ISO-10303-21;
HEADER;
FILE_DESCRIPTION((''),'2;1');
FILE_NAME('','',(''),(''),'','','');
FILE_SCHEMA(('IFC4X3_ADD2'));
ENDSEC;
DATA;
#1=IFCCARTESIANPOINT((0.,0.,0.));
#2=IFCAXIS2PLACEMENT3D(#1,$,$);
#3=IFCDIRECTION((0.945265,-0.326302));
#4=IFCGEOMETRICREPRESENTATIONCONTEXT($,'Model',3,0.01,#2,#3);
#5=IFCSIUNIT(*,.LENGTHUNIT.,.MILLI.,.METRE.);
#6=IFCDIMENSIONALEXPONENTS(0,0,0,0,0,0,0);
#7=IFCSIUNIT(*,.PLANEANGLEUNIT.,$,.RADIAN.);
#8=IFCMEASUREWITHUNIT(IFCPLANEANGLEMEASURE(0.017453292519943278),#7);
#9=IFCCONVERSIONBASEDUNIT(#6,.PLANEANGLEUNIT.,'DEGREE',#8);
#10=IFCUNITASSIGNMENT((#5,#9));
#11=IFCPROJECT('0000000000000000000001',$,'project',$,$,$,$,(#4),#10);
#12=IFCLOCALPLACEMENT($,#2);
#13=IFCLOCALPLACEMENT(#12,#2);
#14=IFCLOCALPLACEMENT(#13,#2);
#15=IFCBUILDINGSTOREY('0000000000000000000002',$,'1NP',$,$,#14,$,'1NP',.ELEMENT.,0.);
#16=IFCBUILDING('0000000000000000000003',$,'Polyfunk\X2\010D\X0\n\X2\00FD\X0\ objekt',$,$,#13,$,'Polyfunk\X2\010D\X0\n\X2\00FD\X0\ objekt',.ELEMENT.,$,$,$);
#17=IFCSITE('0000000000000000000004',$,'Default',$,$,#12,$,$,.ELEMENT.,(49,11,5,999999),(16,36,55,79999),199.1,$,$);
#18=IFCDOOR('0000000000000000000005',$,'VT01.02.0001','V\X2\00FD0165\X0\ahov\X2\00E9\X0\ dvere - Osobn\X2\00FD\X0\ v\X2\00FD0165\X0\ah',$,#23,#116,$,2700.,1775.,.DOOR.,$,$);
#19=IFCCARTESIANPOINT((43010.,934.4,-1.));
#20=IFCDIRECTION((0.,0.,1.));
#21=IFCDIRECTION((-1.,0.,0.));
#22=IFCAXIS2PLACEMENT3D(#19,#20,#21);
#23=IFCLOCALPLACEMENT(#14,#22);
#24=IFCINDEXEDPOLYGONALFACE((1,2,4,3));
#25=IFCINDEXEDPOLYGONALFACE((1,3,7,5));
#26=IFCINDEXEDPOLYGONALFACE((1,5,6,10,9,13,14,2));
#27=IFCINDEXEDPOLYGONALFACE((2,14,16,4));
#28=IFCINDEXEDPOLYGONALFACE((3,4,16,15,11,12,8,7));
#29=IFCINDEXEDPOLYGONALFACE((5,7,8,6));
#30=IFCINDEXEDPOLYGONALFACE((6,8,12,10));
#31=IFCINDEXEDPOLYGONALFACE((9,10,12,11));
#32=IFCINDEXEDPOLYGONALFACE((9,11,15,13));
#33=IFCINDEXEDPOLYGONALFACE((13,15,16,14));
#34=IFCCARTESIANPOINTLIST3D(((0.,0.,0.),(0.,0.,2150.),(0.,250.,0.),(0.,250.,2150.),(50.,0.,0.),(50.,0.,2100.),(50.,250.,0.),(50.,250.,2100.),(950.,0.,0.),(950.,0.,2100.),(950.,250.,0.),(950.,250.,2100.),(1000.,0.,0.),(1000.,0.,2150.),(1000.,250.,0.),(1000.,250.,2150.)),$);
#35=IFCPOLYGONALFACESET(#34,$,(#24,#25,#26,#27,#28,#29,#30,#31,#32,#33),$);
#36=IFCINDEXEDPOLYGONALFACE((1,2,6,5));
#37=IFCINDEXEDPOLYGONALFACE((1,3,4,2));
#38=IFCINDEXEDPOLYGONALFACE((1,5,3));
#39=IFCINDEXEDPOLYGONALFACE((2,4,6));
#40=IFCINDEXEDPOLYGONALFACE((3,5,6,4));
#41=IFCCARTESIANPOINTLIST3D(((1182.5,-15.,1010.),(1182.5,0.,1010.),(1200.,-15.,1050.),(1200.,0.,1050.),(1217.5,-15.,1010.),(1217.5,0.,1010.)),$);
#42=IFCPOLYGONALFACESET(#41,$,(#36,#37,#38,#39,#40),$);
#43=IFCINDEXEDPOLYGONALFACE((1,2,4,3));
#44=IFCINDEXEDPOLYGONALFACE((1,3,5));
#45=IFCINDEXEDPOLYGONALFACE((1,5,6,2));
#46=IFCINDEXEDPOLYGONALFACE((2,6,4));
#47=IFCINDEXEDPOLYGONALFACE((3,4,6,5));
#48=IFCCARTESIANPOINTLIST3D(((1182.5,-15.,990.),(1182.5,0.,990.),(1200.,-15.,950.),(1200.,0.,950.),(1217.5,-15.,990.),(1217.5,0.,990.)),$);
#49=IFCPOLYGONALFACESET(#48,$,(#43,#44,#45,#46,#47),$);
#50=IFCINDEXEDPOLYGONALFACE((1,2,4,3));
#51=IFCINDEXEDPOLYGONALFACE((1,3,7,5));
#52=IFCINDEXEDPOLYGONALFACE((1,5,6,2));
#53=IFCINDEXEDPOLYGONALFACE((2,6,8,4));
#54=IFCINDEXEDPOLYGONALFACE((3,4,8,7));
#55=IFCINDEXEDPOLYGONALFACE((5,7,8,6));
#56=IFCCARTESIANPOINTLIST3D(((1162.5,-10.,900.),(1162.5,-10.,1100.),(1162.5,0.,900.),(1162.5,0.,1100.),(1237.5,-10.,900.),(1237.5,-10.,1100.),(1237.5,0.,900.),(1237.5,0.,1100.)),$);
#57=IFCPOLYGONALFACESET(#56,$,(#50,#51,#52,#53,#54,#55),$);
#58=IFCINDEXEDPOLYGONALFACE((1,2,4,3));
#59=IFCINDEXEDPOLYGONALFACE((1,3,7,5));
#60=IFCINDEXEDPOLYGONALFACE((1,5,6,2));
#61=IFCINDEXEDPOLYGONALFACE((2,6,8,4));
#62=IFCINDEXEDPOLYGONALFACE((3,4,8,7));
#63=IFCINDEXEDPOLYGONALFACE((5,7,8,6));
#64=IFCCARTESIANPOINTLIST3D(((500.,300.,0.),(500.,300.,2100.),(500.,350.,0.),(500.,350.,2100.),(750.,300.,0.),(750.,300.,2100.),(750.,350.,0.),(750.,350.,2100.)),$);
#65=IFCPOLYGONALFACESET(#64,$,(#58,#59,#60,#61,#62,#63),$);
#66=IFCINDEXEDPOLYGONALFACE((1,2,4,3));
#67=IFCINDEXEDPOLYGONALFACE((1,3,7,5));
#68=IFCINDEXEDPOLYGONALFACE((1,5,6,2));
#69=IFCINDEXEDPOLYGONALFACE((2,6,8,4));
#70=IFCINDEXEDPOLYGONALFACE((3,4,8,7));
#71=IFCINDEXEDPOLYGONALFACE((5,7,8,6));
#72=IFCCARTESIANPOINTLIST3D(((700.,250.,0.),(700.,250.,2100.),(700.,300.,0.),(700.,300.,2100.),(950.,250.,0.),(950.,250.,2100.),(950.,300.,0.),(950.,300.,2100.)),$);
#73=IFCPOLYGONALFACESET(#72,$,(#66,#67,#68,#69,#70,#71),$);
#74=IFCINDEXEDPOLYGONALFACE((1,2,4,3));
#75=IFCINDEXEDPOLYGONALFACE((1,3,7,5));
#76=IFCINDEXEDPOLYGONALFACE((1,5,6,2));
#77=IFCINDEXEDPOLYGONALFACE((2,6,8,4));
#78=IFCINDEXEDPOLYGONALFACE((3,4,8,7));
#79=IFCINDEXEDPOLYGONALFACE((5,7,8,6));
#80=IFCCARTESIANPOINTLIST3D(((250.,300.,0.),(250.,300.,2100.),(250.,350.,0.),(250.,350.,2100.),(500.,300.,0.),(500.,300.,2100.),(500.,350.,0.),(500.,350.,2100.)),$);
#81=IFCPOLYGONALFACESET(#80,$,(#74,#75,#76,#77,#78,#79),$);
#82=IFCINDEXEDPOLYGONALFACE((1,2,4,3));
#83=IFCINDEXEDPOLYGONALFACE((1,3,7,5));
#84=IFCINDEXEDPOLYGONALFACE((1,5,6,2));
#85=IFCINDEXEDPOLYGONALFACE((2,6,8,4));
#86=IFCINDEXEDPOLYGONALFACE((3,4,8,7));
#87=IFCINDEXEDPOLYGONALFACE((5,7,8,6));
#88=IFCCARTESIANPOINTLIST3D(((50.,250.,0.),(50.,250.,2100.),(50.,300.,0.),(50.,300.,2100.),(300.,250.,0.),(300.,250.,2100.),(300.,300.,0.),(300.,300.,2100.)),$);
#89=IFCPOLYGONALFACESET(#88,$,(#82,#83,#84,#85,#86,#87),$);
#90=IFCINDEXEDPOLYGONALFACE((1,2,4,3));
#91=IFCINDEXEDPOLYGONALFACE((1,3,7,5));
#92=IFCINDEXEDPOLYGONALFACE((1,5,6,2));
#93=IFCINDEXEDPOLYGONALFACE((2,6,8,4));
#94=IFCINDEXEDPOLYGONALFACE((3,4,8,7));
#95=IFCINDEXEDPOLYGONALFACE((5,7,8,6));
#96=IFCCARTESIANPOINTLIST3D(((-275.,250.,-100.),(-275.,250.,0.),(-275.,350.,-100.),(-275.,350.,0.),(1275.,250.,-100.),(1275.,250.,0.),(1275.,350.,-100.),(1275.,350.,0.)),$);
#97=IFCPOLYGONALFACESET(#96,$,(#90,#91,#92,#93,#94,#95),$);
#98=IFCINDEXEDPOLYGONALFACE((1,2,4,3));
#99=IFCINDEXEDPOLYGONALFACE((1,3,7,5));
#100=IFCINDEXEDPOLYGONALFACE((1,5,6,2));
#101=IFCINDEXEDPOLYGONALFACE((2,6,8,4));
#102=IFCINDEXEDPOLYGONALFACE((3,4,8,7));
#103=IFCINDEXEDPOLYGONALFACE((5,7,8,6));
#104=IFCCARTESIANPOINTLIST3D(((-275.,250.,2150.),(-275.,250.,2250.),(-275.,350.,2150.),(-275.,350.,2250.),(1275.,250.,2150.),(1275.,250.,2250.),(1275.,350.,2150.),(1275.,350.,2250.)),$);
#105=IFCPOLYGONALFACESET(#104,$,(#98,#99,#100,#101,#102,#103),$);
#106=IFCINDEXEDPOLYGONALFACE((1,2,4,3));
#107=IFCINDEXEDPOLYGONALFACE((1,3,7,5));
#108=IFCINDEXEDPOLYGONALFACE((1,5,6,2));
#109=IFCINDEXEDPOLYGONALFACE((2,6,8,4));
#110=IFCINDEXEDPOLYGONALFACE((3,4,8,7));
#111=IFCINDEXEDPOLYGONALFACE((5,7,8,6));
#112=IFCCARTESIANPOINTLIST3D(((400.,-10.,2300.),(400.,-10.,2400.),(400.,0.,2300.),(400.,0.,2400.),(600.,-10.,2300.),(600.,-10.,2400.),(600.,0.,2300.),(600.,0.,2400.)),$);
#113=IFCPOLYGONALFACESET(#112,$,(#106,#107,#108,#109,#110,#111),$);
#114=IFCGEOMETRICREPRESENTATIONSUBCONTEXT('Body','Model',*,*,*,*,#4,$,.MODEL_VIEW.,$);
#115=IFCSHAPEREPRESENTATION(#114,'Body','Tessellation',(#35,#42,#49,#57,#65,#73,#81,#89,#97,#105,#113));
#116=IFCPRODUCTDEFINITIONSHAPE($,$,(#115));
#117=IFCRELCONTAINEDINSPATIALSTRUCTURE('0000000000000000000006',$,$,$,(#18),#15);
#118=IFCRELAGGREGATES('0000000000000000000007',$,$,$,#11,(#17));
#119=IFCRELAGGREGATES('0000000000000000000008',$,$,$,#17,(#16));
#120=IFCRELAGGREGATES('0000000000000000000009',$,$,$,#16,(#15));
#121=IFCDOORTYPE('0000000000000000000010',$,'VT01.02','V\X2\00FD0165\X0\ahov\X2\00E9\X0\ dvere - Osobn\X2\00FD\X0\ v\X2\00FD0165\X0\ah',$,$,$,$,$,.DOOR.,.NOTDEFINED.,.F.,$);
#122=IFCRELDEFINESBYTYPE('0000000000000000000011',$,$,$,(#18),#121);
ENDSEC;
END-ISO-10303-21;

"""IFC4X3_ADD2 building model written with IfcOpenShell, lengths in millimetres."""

from ifc_helpers import new_model, entity, si_unit, converted_unit, direction, frame, frame_2d, origin, origin_2d_with_axis, place, context, subcontext, project, spatial, polyline, rectangle, outline, extrude, source, transform, mapped, type_object, type_shapes, element, save


model = new_model("IFC4X3_ADD2")

# Units and contexts
model_context = context("Model", 3, precision=0.01, world=origin(), true_north=direction((0.945265, -0.326302)))
body_context = subcontext(model_context, "Body", "Model", "MODEL_VIEW")
ifc_project = project(units=[si_unit("LENGTHUNIT", "METRE", prefix="MILLI"), converted_unit("PLANEANGLEUNIT", "DEGREE", entity("IfcPlaneAngleMeasure", 0.017453292519943278), si_unit("PLANEANGLEUNIT", "RADIAN"), dimensions=[0, 0, 0, 0, 0, 0, 0])], contexts=[model_context])

# Site, building, storey
site_placement = place(None, origin())
site = spatial("IfcSite", under=ifc_project, at=site_placement, Name="Default", CompositionType="ELEMENT", RefLatitude=(49, 11, 5, 999999), RefLongitude=(16, 36, 55, 79999), RefElevation=199.1)
building_placement = place(site_placement, origin())
building = spatial("IfcBuilding", under=site, at=building_placement, Name="Polyfunkčný objekt", LongName="Polyfunkčný objekt", CompositionType="ELEMENT")
storey_placement = place(building_placement, origin())
storey = spatial("IfcBuildingStorey", under=building, at=storey_placement, Name="1NP", LongName="1NP", CompositionType="ELEMENT", Elevation=0.0)

# Door
door_type_1 = type_object("IfcDoorType", Name="VT01.02", Description="Výťahové dvere - Osobný výťah", OperationType="NOTDEFINED", ParameterTakesPrecedence=False, PredefinedType="DOOR")
shared_shape_1 = source(origin(), body_context, "Body", "SweptSolid", [
    extrude(outline(polyline([(-1087.5, -500.0), (1062.5, -500.0), (1062.5, -450.0), (-1037.5, -450.0), (-1037.5, 450.0), (1062.5, 450.0), (1062.5, 500.0), (-1087.5, 500.0), (-1087.5, -500.0)])), frame((500.0, 0.0, 1062.5), z_axis=(0.0, 1.0, 0.0), x_axis=(0.0, 0.0, -1.0)), (0.0, 0.0, 1.0), 250.0),
    extrude(outline(polyline([(-24.4, -10.7), (19.2, -10.7), (5.2, 21.4), (-24.4, -10.7)])), frame((1200.0, -15.0, 1023.3), z_axis=(0.0, 1.0, 0.0), x_axis=(0.400819, 0.0, -0.916157)), (0.0, 0.0, 1.0), 15.0),
    extrude(outline(polyline([(-24.4, -10.7), (19.2, -10.7), (5.2, 21.4), (-24.4, -10.7)])), frame((1200.0, -15.0, 976.7), z_axis=(0.0, 1.0, 0.0), x_axis=(-0.400819, 0.0, 0.916157)), (0.0, 0.0, 1.0), 15.0),
    extrude(rectangle(XDim=10.0, YDim=75.0, at=frame_2d((0.0, 0.0), x_axis=(1.0, 0.0))), frame((1200.0, -5.0, 900.0), z_axis=(0.0, 0.0, 1.0), x_axis=(0.0, 1.0, 0.0)), (0.0, 0.0, 1.0), 200.0),
    extrude(rectangle(XDim=50.0, YDim=250.0, at=origin_2d_with_axis()), frame((625.0, 325.0, 0.0), z_axis=(0.0, 0.0, 1.0), x_axis=(0.0, -1.0, 0.0)), (0.0, 0.0, 1.0), 2100.0),
    extrude(rectangle(XDim=50.0, YDim=250.0, at=frame_2d((0.0, 0.0), x_axis=(1.0, 0.0))), frame((825.0, 275.0, 0.0), z_axis=(0.0, 0.0, 1.0), x_axis=(0.0, -1.0, 0.0)), (0.0, 0.0, 1.0), 2100.0),
    extrude(rectangle(XDim=250.0, YDim=50.0, at=frame_2d((0.0, 0.0), x_axis=(1.0, 0.0))), frame((375.0, 325.0, 0.0), z_axis=(0.0, 0.0, 1.0), x_axis=(-1.0, 0.0, 0.0)), (0.0, 0.0, 1.0), 2100.0),
    extrude(rectangle(XDim=250.0, YDim=50.0, at=frame_2d((0.0, 0.0), x_axis=(1.0, 0.0))), frame((175.0, 275.0, 0.0), z_axis=(0.0, 0.0, 1.0), x_axis=(-1.0, 0.0, 0.0)), (0.0, 0.0, 1.0), 2100.0),
    extrude(rectangle(XDim=1550.0, YDim=100.0, at=frame_2d((0.0, 0.0), x_axis=(1.0, 0.0))), frame((500.0, 300.0, -100.0), z_axis=(0.0, 0.0, 1.0), x_axis=(-1.0, 0.0, 0.0)), (0.0, 0.0, 1.0), 100.0),
    extrude(rectangle(XDim=1550.0, YDim=100.0, at=frame_2d((0.0, 0.0), x_axis=(1.0, 0.0))), frame((500.0, 300.0, 2150.0), z_axis=(0.0, 0.0, 1.0), x_axis=(-1.0, 0.0, 0.0)), (0.0, 0.0, 1.0), 100.0),
    extrude(rectangle(XDim=10.0, YDim=200.0, at=frame_2d((0.0, 0.0), x_axis=(1.0, 0.0))), frame((500.0, -5.0, 2300.0), z_axis=(0.0, 0.0, 1.0), x_axis=(0.0, 1.0, 0.0)), (0.0, 0.0, 1.0), 100.0),
])
type_shapes(door_type_1, [shared_shape_1])
door_1_placement = place(storey_placement, frame((43010.0, 934.4, -1.0), z_axis=(0.0, 0.0, 1.0), x_axis=(-1.0, 0.0, 0.0)))
element("IfcDoor", 1, at=door_1_placement, inside=storey, type_object=door_type_1, Name="VT01.02.0001", Description="Výťahové dvere - Osobný výťah", OverallHeight=2700.0, OverallWidth=1775.0, PredefinedType="DOOR", context=body_context, shape_type="MappedRepresentation", body=[
    mapped(shared_shape_1, transform((0.0, 0.0, 0.0), scale=1.0)),
])

save(model, "model.ifc")
